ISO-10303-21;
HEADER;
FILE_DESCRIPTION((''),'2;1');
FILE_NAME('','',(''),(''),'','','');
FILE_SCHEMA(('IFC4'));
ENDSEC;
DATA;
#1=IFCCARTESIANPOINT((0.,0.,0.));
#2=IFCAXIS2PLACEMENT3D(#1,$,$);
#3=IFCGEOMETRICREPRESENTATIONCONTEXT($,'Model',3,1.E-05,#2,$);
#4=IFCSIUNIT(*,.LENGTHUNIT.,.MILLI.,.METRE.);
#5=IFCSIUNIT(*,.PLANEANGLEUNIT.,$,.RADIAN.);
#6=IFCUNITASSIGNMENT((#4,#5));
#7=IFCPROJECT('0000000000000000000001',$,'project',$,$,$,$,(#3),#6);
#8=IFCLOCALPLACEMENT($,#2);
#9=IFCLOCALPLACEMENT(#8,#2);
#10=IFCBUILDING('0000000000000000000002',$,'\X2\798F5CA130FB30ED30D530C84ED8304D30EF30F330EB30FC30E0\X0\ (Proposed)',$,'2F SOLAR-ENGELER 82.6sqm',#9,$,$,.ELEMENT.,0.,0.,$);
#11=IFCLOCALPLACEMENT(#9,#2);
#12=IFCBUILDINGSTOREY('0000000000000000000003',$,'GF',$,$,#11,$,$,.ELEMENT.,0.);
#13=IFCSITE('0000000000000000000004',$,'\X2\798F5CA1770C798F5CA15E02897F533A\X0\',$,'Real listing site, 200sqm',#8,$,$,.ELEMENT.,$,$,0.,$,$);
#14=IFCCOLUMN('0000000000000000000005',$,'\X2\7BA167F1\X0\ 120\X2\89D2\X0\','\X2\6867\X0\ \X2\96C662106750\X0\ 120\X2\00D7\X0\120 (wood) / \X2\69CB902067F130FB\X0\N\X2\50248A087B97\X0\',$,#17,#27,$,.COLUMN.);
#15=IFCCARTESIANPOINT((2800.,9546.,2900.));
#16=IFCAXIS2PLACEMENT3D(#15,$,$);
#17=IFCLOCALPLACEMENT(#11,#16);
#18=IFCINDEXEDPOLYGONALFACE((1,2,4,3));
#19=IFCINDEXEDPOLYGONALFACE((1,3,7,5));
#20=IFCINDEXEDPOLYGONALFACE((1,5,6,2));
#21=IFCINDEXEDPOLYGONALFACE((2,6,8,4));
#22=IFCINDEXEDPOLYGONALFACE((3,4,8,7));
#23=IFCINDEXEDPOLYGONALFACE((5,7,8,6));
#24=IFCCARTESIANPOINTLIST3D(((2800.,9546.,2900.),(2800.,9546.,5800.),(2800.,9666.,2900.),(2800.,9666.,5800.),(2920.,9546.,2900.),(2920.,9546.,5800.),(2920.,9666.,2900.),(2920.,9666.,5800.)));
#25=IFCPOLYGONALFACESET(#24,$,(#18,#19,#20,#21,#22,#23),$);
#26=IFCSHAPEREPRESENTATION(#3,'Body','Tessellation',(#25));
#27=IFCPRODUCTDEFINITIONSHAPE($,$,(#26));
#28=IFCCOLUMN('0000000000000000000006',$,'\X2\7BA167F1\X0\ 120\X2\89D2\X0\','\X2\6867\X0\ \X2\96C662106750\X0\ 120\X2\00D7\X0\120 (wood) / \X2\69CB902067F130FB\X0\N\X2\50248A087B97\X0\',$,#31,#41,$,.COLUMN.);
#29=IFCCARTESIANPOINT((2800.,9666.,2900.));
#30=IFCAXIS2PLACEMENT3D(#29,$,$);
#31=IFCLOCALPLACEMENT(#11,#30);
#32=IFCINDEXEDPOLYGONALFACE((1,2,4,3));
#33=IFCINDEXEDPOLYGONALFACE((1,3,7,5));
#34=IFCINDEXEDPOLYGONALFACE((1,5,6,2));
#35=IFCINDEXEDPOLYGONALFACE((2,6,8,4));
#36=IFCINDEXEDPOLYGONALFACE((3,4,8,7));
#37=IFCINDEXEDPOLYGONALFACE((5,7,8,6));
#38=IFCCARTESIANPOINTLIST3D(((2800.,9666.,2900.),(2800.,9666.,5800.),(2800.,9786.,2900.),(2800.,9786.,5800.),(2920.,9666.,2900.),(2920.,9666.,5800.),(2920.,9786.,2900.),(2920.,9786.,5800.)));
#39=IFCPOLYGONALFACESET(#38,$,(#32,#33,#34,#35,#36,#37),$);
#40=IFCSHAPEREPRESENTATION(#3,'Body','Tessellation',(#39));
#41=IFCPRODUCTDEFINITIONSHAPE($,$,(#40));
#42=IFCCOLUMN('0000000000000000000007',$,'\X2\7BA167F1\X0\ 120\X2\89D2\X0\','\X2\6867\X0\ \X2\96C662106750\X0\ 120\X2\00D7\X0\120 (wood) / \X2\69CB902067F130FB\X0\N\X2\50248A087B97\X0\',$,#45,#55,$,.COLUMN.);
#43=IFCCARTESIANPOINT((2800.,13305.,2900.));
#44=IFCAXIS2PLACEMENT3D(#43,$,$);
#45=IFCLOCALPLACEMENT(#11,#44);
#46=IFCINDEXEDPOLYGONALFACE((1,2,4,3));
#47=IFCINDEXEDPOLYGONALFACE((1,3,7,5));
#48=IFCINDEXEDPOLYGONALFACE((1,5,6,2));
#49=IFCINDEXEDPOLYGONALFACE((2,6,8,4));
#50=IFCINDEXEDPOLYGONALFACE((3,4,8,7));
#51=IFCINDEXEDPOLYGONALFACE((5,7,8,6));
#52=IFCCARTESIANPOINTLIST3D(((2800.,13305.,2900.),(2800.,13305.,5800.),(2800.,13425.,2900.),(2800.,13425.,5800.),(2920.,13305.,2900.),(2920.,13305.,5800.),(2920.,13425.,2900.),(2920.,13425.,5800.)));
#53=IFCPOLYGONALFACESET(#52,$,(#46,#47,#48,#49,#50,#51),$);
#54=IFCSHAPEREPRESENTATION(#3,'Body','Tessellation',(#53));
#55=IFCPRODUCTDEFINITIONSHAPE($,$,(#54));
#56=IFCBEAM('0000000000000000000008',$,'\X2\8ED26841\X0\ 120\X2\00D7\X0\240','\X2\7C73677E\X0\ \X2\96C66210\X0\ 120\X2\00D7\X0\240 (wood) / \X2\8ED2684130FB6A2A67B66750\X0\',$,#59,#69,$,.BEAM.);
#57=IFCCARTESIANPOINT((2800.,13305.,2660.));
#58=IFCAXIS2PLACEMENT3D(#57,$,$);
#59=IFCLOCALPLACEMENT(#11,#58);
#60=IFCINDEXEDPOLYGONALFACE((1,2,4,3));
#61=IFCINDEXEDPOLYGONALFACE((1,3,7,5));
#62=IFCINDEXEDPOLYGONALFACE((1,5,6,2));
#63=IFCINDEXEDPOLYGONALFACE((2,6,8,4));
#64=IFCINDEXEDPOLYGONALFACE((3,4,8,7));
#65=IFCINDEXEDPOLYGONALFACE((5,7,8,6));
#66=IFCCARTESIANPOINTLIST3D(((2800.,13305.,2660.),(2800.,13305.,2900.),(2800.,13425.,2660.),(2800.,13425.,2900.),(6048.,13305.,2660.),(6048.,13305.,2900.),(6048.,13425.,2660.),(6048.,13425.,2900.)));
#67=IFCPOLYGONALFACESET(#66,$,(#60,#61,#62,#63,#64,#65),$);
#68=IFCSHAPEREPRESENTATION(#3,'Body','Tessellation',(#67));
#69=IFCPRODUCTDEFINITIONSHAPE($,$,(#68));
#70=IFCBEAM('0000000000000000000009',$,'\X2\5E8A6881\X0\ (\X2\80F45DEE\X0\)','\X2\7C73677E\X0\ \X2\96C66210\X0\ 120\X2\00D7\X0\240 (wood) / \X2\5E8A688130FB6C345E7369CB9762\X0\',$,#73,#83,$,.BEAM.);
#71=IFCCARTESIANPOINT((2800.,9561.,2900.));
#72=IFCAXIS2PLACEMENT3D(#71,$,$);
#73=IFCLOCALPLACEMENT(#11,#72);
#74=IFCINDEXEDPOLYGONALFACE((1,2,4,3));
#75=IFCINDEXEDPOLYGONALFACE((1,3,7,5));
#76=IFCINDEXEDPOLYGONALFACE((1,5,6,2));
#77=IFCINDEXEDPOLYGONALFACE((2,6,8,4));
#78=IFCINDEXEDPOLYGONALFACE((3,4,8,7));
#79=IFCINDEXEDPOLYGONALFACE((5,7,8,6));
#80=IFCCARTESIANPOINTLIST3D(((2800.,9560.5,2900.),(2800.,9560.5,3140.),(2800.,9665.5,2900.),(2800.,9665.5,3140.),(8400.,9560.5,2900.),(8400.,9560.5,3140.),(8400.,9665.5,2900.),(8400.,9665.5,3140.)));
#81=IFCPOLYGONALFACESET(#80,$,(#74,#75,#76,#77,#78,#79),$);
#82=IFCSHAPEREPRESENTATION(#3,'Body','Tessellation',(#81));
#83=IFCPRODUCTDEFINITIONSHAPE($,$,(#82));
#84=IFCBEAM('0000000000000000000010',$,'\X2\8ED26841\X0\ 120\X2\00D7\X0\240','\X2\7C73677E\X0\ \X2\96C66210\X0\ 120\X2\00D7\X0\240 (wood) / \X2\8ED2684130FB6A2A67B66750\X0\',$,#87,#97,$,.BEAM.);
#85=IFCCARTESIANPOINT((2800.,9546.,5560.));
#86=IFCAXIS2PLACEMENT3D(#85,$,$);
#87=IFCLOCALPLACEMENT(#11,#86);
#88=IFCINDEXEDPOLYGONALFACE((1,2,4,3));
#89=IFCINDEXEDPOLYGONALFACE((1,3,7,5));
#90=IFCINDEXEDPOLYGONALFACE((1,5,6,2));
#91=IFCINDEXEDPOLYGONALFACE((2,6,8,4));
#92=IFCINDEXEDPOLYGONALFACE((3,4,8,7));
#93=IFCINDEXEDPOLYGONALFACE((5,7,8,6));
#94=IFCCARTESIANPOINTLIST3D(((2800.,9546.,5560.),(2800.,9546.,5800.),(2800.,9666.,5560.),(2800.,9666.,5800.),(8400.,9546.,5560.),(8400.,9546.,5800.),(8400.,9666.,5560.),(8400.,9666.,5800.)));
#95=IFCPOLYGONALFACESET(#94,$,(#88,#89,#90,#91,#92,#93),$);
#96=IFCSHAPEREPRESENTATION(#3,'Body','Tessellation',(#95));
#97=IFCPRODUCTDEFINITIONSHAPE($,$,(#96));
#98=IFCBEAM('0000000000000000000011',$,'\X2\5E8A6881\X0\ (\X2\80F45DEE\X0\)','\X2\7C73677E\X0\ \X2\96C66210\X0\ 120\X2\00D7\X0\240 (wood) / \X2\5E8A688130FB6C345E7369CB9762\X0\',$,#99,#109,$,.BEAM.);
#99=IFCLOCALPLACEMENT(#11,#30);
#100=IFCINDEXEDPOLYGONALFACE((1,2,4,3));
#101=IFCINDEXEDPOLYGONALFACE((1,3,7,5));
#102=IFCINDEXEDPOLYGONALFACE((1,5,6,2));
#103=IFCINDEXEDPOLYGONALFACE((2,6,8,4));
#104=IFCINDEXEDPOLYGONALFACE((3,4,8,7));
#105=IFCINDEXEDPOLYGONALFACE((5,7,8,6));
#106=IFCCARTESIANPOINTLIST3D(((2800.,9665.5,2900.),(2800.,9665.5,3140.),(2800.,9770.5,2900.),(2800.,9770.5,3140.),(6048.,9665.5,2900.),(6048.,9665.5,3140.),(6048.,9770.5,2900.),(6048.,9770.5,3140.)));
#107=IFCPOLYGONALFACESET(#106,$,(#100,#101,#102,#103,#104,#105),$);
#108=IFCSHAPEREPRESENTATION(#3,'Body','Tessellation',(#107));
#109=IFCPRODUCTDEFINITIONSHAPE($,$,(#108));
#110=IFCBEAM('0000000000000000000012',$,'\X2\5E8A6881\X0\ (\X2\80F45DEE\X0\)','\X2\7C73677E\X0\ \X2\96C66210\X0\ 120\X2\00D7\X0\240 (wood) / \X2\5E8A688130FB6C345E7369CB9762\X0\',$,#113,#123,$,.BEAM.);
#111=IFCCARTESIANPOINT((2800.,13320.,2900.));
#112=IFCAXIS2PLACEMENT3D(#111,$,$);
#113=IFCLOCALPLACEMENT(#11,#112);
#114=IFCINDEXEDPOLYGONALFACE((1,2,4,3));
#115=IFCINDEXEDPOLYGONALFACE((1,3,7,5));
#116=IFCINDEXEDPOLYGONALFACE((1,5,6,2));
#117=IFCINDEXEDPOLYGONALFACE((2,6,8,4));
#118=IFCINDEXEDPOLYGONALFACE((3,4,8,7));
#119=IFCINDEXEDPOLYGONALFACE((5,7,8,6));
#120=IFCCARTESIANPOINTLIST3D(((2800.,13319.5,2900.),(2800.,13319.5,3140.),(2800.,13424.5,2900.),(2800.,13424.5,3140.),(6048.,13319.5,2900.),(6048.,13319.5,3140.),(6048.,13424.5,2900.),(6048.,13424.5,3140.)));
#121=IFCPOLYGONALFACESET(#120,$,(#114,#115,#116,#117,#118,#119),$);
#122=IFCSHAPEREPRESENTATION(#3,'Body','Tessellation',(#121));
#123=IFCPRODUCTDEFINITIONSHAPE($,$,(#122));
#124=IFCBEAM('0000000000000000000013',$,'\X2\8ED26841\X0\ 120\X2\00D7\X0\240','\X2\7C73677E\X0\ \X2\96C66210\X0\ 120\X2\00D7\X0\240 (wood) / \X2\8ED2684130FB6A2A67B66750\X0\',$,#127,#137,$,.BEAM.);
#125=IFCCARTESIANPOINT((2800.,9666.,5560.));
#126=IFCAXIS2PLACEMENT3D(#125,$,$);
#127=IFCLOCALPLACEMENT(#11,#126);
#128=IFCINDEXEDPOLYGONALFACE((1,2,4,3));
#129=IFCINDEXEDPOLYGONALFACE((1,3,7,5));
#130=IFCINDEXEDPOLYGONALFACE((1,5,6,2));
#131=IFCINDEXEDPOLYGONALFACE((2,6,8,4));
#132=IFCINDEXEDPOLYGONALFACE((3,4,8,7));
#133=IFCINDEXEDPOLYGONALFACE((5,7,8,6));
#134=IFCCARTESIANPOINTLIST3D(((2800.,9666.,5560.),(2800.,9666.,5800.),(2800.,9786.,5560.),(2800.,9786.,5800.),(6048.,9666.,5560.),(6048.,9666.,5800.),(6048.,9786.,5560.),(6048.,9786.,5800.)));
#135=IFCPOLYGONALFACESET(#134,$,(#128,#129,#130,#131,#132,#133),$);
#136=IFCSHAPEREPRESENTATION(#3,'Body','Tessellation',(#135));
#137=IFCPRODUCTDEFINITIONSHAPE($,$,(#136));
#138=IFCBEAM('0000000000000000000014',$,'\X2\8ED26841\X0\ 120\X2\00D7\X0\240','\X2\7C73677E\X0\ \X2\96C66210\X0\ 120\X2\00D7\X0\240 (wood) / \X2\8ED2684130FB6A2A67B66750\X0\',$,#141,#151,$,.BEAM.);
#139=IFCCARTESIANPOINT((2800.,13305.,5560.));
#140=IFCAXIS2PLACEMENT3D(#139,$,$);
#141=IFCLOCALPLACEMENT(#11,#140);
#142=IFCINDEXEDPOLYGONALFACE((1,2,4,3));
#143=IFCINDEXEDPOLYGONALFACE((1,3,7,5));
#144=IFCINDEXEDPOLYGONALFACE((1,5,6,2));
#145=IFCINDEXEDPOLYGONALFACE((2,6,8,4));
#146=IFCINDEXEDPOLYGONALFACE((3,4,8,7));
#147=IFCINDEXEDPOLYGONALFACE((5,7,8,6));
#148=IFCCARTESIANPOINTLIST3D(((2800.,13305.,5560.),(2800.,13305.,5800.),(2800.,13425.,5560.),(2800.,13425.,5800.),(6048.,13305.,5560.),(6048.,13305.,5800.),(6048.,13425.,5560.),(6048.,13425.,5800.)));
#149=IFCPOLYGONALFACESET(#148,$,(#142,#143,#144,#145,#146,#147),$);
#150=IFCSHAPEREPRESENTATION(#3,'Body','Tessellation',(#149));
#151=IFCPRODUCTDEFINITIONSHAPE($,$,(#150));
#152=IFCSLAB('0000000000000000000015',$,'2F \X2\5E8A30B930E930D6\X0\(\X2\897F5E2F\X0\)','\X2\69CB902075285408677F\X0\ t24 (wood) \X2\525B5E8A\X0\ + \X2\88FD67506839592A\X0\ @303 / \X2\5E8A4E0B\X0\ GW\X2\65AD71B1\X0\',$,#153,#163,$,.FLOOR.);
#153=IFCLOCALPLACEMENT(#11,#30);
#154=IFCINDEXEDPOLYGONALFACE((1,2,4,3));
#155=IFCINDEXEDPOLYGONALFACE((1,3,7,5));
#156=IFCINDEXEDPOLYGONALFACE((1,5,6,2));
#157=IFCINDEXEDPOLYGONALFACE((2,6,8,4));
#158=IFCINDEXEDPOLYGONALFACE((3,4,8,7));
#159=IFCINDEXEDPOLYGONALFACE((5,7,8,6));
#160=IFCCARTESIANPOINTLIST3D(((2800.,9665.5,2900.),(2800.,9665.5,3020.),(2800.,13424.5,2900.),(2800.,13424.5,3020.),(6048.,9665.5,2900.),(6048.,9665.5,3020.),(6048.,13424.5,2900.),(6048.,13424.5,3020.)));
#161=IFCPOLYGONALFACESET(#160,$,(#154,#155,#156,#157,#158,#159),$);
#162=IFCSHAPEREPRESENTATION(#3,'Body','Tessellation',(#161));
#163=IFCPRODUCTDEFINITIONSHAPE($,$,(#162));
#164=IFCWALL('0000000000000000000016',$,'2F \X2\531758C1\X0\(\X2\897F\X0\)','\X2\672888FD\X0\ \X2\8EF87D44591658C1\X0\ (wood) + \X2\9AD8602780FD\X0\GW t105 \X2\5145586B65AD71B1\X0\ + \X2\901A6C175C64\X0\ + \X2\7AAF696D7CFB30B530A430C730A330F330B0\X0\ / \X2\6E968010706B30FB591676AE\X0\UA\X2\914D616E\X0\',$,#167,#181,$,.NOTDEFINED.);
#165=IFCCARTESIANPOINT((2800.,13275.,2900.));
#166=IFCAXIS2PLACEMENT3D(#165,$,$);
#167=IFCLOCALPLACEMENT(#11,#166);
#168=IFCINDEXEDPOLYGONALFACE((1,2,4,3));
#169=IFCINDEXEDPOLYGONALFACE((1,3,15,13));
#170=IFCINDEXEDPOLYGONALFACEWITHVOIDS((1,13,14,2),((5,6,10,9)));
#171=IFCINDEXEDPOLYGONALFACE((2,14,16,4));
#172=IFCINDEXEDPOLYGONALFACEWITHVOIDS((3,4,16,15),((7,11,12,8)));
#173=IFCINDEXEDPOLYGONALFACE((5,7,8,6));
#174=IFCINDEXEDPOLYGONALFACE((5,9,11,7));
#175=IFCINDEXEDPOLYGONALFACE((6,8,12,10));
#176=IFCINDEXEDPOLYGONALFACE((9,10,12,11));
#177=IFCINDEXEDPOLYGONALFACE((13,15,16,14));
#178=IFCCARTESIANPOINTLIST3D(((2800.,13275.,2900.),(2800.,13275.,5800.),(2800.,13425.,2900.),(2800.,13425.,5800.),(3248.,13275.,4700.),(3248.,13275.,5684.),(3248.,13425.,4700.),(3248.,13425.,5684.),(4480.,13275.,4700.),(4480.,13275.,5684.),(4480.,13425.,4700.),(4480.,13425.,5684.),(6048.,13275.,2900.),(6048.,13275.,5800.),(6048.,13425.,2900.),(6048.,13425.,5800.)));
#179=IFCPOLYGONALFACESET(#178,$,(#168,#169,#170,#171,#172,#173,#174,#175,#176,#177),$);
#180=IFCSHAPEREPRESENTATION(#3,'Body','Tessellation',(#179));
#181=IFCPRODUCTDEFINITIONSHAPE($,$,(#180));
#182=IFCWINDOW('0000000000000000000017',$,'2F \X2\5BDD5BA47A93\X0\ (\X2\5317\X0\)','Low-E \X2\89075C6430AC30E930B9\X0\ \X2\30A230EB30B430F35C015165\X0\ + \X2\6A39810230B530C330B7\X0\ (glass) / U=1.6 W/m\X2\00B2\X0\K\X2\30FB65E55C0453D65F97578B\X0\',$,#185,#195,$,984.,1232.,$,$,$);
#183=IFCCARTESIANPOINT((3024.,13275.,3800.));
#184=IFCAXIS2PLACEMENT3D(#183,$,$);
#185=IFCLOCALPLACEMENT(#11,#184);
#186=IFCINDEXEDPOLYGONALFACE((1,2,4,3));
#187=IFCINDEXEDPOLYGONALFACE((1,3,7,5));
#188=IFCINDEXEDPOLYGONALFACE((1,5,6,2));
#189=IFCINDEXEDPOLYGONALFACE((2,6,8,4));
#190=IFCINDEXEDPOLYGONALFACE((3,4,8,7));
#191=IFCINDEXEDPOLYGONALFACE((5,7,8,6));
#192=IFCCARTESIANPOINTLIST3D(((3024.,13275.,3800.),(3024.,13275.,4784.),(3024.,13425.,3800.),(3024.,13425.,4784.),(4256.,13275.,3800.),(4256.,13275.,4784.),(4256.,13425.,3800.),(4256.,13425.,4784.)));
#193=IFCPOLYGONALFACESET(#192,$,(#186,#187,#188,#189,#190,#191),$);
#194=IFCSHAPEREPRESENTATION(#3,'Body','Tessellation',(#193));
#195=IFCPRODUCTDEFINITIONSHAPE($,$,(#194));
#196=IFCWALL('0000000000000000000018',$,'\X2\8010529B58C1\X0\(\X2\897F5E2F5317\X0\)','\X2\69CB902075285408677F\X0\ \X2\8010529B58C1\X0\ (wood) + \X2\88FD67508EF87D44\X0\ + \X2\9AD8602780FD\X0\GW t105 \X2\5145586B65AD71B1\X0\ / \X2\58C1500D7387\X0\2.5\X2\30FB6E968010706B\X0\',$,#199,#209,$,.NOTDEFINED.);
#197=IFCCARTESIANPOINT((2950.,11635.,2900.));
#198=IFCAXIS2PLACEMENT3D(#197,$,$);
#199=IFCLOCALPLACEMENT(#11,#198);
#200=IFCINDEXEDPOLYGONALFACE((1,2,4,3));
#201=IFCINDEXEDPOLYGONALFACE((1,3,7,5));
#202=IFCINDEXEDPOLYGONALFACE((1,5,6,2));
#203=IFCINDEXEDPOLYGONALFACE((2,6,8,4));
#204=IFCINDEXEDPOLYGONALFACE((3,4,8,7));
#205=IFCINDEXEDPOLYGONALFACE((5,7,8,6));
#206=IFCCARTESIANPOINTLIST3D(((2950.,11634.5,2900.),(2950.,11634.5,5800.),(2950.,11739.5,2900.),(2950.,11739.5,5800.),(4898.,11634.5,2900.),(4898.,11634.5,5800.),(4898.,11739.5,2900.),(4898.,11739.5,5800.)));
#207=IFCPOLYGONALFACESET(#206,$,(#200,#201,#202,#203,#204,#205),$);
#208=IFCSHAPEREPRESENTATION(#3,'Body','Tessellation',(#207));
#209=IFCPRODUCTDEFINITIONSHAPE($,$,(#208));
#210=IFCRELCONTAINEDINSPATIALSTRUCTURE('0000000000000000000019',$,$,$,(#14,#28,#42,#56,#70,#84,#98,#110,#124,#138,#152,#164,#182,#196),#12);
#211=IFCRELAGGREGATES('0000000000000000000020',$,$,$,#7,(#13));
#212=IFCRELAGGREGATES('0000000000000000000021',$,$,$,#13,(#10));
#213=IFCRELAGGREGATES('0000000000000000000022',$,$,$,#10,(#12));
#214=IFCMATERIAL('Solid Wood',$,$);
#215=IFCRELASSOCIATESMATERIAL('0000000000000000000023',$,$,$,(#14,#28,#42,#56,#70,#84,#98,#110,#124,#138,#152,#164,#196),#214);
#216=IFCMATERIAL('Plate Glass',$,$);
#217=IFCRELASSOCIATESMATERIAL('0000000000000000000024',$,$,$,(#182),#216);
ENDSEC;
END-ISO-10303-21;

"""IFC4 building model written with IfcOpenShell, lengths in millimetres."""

from ifc_helpers import new_model, si_unit, frame, frame_2d, origin, place, context, project, spatial, rectangle, extrude, material, element, fill, save


model = new_model("IFC4")

# Units and contexts
model_context = context("Model", 3, precision=1e-05, world=origin())
ifc_project = project(units=[si_unit("LENGTHUNIT", "METRE", prefix="MILLI"), si_unit("PLANEANGLEUNIT", "RADIAN")], contexts=[model_context])

# Site, building, storey
site_placement = place(None, origin())
site = spatial("IfcSite", under=ifc_project, at=site_placement, Name="福岡県福岡市西区", ObjectType="Real listing site, 200sqm", CompositionType="ELEMENT", RefElevation=0.0)
building_placement = place(site_placement, origin())
building = spatial("IfcBuilding", under=site, at=building_placement, Name="福岡・ロフト付きワンルーム (Proposed)", ObjectType="2F SOLAR-ENGELER 82.6sqm", CompositionType="ELEMENT", ElevationOfRefHeight=0.0, ElevationOfTerrain=0.0)
storey_placement = place(building_placement, origin())
storey = spatial("IfcBuildingStorey", under=building, at=storey_placement, Name="GF", CompositionType="ELEMENT", Elevation=0.0)

# Columns
ifc_material_1 = material(Name="Solid Wood")
column_1_placement = place(storey_placement, frame((2800.0, 9546.0, 2900.0)))
element("IfcColumn", 1, at=column_1_placement, inside=storey, material=ifc_material_1, Name="管柱 120角", Description="桧 集成材 120×120 (wood) / 構造柱・N値計算", PredefinedType="COLUMN", context=model_context, shape_type="SweptSolid", body=[
    extrude(rectangle(XDim=120.0, YDim=120.0, at=frame_2d((60.0, 60.0))), frame((2800.0, 9546.0, 2900.0)), (0.0, 0.0, 1.0), 2900.0),
])
column_2_placement = place(storey_placement, frame((2800.0, 9666.0, 2900.0)))
element("IfcColumn", 2, at=column_2_placement, inside=storey, material=ifc_material_1, Name="管柱 120角", Description="桧 集成材 120×120 (wood) / 構造柱・N値計算", PredefinedType="COLUMN", context=model_context, shape_type="SweptSolid", body=[
    extrude(rectangle(XDim=120.0, YDim=120.0, at=frame_2d((60.0, 60.0))), frame((2800.0, 9666.0, 2900.0)), (0.0, 0.0, 1.0), 2900.0),
])
column_3_placement = place(storey_placement, frame((2800.0, 13305.0, 2900.0)))
element("IfcColumn", 3, at=column_3_placement, inside=storey, material=ifc_material_1, Name="管柱 120角", Description="桧 集成材 120×120 (wood) / 構造柱・N値計算", PredefinedType="COLUMN", context=model_context, shape_type="SweptSolid", body=[
    extrude(rectangle(XDim=120.0, YDim=120.0, at=frame_2d((60.0, 60.0))), frame((2800.0, 13305.0, 2900.0)), (0.0, 0.0, 1.0), 2900.0),
])

# Beams
beam_1_placement = place(storey_placement, frame((2800.0, 13305.0, 2660.0)))
element("IfcBeam", 4, at=beam_1_placement, inside=storey, material=ifc_material_1, Name="軒桁 120×240", Description="米松 集成 120×240 (wood) / 軒桁・横架材", PredefinedType="BEAM", context=model_context, shape_type="SweptSolid", body=[
    extrude(rectangle(XDim=3248.0, YDim=120.0, at=frame_2d((1624.0, 60.0))), frame((2800.0, 13305.0, 2660.0)), (0.0, 0.0, 1.0), 240.0),
])
beam_2_placement = place(storey_placement, frame((2800.0, 9561.0, 2900.0)))
element("IfcBeam", 5, at=beam_2_placement, inside=storey, material=ifc_material_1, Name="床梁 (胴差)", Description="米松 集成 120×240 (wood) / 床梁・水平構面", PredefinedType="BEAM", context=model_context, shape_type="SweptSolid", body=[
    extrude(rectangle(XDim=5600.0, YDim=105.0, at=frame_2d((2800.0, 52.0))), frame((2800.0, 9561.0, 2900.0)), (0.0, 0.0, 1.0), 240.0),
])
beam_3_placement = place(storey_placement, frame((2800.0, 9546.0, 5560.0)))
element("IfcBeam", 6, at=beam_3_placement, inside=storey, material=ifc_material_1, Name="軒桁 120×240", Description="米松 集成 120×240 (wood) / 軒桁・横架材", PredefinedType="BEAM", context=model_context, shape_type="SweptSolid", body=[
    extrude(rectangle(XDim=5600.0, YDim=120.0, at=frame_2d((2800.0, 60.0))), frame((2800.0, 9546.0, 5560.0)), (0.0, 0.0, 1.0), 240.0),
])
beam_4_placement = place(storey_placement, frame((2800.0, 9666.0, 2900.0)))
element("IfcBeam", 7, at=beam_4_placement, inside=storey, material=ifc_material_1, Name="床梁 (胴差)", Description="米松 集成 120×240 (wood) / 床梁・水平構面", PredefinedType="BEAM", context=model_context, shape_type="SweptSolid", body=[
    extrude(rectangle(XDim=3248.0, YDim=105.0, at=frame_2d((1624.0, 52.0))), frame((2800.0, 9666.0, 2900.0)), (0.0, 0.0, 1.0), 240.0),
])
beam_5_placement = place(storey_placement, frame((2800.0, 13320.0, 2900.0)))
element("IfcBeam", 8, at=beam_5_placement, inside=storey, material=ifc_material_1, Name="床梁 (胴差)", Description="米松 集成 120×240 (wood) / 床梁・水平構面", PredefinedType="BEAM", context=model_context, shape_type="SweptSolid", body=[
    extrude(rectangle(XDim=3248.0, YDim=105.0, at=frame_2d((1624.0, 52.0))), frame((2800.0, 13320.0, 2900.0)), (0.0, 0.0, 1.0), 240.0),
])
beam_6_placement = place(storey_placement, frame((2800.0, 9666.0, 5560.0)))
element("IfcBeam", 9, at=beam_6_placement, inside=storey, material=ifc_material_1, Name="軒桁 120×240", Description="米松 集成 120×240 (wood) / 軒桁・横架材", PredefinedType="BEAM", context=model_context, shape_type="SweptSolid", body=[
    extrude(rectangle(XDim=3248.0, YDim=120.0, at=frame_2d((1624.0, 60.0))), frame((2800.0, 9666.0, 5560.0)), (0.0, 0.0, 1.0), 240.0),
])
beam_7_placement = place(storey_placement, frame((2800.0, 13305.0, 5560.0)))
element("IfcBeam", 10, at=beam_7_placement, inside=storey, material=ifc_material_1, Name="軒桁 120×240", Description="米松 集成 120×240 (wood) / 軒桁・横架材", PredefinedType="BEAM", context=model_context, shape_type="SweptSolid", body=[
    extrude(rectangle(XDim=3248.0, YDim=120.0, at=frame_2d((1624.0, 60.0))), frame((2800.0, 13305.0, 5560.0)), (0.0, 0.0, 1.0), 240.0),
])

# Slab
slab_placement = place(storey_placement, frame((2800.0, 9666.0, 2900.0)))
element("IfcSlab", 11, at=slab_placement, inside=storey, material=ifc_material_1, Name="2F 床スラブ(西帯)", Description="構造用合板 t24 (wood) 剛床 + 製材根太 @303 / 床下 GW断熱", PredefinedType="FLOOR", context=model_context, shape_type="SweptSolid", body=[
    extrude(rectangle(XDim=3248.0, YDim=3759.0, at=frame_2d((1624.0, 1879.0))), frame((2800.0, 9666.0, 2900.0)), (0.0, 0.0, 1.0), 120.0),
])

# Wall, opening, window
wall_1_placement = place(storey_placement, frame((2800.0, 13275.0, 2900.0)))
wall_1 = element("IfcWall", 12, at=wall_1_placement, inside=storey, material=ifc_material_1, Name="2F 北壁(西)", Description="木製 軸組外壁 (wood) + 高性能GW t105 充填断熱 + 通気層 + 窯業系サイディング / 準耐火・外皮UA配慮", PredefinedType="NOTDEFINED", context=model_context, shape_type="SweptSolid", body=[
    extrude(rectangle(XDim=3248.0, YDim=150.0, at=frame_2d((1624.0, 75.0))), frame((2800.0, 13275.0, 2900.0)), (0.0, 0.0, 1.0), 2900.0),
])
opening_placement = place(storey_placement, frame((3024.0, 13275.0, 3800.0)))
opening = element("IfcOpeningElement", 13, at=opening_placement, cuts=wall_1, PredefinedType="NOTDEFINED", context=model_context, shape_type="SweptSolid", body=[
    extrude(rectangle(XDim=1232.0, YDim=150.0, at=frame_2d((616.0, 75.0))), frame((3024.0, 13275.0, 3800.0)), (0.0, 0.0, 1.0), 984.0),
])
ifc_material_2 = material(Name="Plate Glass")
window_placement = place(storey_placement, frame((3024.0, 13275.0, 3800.0)))
window = element("IfcWindow", 14, at=window_placement, inside=storey, material=ifc_material_2, Name="2F 寝室窓 (北)", Description="Low-E 複層ガラス アルゴン封入 + 樹脂サッシ (glass) / U=1.6 W/m²K・日射取得型", OverallHeight=984.0, OverallWidth=1232.0, context=model_context, shape_type="SweptSolid", body=[
    extrude(rectangle(XDim=1232.0, YDim=150.0, at=frame_2d((616.0, 75.0))), frame((3024.0, 13275.0, 3800.0)), (0.0, 0.0, 1.0), 984.0),
])
fill(opening, window)

# Wall
wall_2_placement = place(storey_placement, frame((2950.0, 11635.0, 2900.0)))
element("IfcWall", 15, at=wall_2_placement, inside=storey, material=ifc_material_1, Name="耐力壁(西帯北)", Description="構造用合板 耐力壁 (wood) + 製材軸組 + 高性能GW t105 充填断熱 / 壁倍率2.5・準耐火", PredefinedType="NOTDEFINED", context=model_context, shape_type="SweptSolid", body=[
    extrude(rectangle(XDim=1948.0, YDim=105.0, at=frame_2d((974.0, 52.0))), frame((2950.0, 11635.0, 2900.0)), (0.0, 0.0, 1.0), 2900.0),
])

save(model, "model.ifc")
